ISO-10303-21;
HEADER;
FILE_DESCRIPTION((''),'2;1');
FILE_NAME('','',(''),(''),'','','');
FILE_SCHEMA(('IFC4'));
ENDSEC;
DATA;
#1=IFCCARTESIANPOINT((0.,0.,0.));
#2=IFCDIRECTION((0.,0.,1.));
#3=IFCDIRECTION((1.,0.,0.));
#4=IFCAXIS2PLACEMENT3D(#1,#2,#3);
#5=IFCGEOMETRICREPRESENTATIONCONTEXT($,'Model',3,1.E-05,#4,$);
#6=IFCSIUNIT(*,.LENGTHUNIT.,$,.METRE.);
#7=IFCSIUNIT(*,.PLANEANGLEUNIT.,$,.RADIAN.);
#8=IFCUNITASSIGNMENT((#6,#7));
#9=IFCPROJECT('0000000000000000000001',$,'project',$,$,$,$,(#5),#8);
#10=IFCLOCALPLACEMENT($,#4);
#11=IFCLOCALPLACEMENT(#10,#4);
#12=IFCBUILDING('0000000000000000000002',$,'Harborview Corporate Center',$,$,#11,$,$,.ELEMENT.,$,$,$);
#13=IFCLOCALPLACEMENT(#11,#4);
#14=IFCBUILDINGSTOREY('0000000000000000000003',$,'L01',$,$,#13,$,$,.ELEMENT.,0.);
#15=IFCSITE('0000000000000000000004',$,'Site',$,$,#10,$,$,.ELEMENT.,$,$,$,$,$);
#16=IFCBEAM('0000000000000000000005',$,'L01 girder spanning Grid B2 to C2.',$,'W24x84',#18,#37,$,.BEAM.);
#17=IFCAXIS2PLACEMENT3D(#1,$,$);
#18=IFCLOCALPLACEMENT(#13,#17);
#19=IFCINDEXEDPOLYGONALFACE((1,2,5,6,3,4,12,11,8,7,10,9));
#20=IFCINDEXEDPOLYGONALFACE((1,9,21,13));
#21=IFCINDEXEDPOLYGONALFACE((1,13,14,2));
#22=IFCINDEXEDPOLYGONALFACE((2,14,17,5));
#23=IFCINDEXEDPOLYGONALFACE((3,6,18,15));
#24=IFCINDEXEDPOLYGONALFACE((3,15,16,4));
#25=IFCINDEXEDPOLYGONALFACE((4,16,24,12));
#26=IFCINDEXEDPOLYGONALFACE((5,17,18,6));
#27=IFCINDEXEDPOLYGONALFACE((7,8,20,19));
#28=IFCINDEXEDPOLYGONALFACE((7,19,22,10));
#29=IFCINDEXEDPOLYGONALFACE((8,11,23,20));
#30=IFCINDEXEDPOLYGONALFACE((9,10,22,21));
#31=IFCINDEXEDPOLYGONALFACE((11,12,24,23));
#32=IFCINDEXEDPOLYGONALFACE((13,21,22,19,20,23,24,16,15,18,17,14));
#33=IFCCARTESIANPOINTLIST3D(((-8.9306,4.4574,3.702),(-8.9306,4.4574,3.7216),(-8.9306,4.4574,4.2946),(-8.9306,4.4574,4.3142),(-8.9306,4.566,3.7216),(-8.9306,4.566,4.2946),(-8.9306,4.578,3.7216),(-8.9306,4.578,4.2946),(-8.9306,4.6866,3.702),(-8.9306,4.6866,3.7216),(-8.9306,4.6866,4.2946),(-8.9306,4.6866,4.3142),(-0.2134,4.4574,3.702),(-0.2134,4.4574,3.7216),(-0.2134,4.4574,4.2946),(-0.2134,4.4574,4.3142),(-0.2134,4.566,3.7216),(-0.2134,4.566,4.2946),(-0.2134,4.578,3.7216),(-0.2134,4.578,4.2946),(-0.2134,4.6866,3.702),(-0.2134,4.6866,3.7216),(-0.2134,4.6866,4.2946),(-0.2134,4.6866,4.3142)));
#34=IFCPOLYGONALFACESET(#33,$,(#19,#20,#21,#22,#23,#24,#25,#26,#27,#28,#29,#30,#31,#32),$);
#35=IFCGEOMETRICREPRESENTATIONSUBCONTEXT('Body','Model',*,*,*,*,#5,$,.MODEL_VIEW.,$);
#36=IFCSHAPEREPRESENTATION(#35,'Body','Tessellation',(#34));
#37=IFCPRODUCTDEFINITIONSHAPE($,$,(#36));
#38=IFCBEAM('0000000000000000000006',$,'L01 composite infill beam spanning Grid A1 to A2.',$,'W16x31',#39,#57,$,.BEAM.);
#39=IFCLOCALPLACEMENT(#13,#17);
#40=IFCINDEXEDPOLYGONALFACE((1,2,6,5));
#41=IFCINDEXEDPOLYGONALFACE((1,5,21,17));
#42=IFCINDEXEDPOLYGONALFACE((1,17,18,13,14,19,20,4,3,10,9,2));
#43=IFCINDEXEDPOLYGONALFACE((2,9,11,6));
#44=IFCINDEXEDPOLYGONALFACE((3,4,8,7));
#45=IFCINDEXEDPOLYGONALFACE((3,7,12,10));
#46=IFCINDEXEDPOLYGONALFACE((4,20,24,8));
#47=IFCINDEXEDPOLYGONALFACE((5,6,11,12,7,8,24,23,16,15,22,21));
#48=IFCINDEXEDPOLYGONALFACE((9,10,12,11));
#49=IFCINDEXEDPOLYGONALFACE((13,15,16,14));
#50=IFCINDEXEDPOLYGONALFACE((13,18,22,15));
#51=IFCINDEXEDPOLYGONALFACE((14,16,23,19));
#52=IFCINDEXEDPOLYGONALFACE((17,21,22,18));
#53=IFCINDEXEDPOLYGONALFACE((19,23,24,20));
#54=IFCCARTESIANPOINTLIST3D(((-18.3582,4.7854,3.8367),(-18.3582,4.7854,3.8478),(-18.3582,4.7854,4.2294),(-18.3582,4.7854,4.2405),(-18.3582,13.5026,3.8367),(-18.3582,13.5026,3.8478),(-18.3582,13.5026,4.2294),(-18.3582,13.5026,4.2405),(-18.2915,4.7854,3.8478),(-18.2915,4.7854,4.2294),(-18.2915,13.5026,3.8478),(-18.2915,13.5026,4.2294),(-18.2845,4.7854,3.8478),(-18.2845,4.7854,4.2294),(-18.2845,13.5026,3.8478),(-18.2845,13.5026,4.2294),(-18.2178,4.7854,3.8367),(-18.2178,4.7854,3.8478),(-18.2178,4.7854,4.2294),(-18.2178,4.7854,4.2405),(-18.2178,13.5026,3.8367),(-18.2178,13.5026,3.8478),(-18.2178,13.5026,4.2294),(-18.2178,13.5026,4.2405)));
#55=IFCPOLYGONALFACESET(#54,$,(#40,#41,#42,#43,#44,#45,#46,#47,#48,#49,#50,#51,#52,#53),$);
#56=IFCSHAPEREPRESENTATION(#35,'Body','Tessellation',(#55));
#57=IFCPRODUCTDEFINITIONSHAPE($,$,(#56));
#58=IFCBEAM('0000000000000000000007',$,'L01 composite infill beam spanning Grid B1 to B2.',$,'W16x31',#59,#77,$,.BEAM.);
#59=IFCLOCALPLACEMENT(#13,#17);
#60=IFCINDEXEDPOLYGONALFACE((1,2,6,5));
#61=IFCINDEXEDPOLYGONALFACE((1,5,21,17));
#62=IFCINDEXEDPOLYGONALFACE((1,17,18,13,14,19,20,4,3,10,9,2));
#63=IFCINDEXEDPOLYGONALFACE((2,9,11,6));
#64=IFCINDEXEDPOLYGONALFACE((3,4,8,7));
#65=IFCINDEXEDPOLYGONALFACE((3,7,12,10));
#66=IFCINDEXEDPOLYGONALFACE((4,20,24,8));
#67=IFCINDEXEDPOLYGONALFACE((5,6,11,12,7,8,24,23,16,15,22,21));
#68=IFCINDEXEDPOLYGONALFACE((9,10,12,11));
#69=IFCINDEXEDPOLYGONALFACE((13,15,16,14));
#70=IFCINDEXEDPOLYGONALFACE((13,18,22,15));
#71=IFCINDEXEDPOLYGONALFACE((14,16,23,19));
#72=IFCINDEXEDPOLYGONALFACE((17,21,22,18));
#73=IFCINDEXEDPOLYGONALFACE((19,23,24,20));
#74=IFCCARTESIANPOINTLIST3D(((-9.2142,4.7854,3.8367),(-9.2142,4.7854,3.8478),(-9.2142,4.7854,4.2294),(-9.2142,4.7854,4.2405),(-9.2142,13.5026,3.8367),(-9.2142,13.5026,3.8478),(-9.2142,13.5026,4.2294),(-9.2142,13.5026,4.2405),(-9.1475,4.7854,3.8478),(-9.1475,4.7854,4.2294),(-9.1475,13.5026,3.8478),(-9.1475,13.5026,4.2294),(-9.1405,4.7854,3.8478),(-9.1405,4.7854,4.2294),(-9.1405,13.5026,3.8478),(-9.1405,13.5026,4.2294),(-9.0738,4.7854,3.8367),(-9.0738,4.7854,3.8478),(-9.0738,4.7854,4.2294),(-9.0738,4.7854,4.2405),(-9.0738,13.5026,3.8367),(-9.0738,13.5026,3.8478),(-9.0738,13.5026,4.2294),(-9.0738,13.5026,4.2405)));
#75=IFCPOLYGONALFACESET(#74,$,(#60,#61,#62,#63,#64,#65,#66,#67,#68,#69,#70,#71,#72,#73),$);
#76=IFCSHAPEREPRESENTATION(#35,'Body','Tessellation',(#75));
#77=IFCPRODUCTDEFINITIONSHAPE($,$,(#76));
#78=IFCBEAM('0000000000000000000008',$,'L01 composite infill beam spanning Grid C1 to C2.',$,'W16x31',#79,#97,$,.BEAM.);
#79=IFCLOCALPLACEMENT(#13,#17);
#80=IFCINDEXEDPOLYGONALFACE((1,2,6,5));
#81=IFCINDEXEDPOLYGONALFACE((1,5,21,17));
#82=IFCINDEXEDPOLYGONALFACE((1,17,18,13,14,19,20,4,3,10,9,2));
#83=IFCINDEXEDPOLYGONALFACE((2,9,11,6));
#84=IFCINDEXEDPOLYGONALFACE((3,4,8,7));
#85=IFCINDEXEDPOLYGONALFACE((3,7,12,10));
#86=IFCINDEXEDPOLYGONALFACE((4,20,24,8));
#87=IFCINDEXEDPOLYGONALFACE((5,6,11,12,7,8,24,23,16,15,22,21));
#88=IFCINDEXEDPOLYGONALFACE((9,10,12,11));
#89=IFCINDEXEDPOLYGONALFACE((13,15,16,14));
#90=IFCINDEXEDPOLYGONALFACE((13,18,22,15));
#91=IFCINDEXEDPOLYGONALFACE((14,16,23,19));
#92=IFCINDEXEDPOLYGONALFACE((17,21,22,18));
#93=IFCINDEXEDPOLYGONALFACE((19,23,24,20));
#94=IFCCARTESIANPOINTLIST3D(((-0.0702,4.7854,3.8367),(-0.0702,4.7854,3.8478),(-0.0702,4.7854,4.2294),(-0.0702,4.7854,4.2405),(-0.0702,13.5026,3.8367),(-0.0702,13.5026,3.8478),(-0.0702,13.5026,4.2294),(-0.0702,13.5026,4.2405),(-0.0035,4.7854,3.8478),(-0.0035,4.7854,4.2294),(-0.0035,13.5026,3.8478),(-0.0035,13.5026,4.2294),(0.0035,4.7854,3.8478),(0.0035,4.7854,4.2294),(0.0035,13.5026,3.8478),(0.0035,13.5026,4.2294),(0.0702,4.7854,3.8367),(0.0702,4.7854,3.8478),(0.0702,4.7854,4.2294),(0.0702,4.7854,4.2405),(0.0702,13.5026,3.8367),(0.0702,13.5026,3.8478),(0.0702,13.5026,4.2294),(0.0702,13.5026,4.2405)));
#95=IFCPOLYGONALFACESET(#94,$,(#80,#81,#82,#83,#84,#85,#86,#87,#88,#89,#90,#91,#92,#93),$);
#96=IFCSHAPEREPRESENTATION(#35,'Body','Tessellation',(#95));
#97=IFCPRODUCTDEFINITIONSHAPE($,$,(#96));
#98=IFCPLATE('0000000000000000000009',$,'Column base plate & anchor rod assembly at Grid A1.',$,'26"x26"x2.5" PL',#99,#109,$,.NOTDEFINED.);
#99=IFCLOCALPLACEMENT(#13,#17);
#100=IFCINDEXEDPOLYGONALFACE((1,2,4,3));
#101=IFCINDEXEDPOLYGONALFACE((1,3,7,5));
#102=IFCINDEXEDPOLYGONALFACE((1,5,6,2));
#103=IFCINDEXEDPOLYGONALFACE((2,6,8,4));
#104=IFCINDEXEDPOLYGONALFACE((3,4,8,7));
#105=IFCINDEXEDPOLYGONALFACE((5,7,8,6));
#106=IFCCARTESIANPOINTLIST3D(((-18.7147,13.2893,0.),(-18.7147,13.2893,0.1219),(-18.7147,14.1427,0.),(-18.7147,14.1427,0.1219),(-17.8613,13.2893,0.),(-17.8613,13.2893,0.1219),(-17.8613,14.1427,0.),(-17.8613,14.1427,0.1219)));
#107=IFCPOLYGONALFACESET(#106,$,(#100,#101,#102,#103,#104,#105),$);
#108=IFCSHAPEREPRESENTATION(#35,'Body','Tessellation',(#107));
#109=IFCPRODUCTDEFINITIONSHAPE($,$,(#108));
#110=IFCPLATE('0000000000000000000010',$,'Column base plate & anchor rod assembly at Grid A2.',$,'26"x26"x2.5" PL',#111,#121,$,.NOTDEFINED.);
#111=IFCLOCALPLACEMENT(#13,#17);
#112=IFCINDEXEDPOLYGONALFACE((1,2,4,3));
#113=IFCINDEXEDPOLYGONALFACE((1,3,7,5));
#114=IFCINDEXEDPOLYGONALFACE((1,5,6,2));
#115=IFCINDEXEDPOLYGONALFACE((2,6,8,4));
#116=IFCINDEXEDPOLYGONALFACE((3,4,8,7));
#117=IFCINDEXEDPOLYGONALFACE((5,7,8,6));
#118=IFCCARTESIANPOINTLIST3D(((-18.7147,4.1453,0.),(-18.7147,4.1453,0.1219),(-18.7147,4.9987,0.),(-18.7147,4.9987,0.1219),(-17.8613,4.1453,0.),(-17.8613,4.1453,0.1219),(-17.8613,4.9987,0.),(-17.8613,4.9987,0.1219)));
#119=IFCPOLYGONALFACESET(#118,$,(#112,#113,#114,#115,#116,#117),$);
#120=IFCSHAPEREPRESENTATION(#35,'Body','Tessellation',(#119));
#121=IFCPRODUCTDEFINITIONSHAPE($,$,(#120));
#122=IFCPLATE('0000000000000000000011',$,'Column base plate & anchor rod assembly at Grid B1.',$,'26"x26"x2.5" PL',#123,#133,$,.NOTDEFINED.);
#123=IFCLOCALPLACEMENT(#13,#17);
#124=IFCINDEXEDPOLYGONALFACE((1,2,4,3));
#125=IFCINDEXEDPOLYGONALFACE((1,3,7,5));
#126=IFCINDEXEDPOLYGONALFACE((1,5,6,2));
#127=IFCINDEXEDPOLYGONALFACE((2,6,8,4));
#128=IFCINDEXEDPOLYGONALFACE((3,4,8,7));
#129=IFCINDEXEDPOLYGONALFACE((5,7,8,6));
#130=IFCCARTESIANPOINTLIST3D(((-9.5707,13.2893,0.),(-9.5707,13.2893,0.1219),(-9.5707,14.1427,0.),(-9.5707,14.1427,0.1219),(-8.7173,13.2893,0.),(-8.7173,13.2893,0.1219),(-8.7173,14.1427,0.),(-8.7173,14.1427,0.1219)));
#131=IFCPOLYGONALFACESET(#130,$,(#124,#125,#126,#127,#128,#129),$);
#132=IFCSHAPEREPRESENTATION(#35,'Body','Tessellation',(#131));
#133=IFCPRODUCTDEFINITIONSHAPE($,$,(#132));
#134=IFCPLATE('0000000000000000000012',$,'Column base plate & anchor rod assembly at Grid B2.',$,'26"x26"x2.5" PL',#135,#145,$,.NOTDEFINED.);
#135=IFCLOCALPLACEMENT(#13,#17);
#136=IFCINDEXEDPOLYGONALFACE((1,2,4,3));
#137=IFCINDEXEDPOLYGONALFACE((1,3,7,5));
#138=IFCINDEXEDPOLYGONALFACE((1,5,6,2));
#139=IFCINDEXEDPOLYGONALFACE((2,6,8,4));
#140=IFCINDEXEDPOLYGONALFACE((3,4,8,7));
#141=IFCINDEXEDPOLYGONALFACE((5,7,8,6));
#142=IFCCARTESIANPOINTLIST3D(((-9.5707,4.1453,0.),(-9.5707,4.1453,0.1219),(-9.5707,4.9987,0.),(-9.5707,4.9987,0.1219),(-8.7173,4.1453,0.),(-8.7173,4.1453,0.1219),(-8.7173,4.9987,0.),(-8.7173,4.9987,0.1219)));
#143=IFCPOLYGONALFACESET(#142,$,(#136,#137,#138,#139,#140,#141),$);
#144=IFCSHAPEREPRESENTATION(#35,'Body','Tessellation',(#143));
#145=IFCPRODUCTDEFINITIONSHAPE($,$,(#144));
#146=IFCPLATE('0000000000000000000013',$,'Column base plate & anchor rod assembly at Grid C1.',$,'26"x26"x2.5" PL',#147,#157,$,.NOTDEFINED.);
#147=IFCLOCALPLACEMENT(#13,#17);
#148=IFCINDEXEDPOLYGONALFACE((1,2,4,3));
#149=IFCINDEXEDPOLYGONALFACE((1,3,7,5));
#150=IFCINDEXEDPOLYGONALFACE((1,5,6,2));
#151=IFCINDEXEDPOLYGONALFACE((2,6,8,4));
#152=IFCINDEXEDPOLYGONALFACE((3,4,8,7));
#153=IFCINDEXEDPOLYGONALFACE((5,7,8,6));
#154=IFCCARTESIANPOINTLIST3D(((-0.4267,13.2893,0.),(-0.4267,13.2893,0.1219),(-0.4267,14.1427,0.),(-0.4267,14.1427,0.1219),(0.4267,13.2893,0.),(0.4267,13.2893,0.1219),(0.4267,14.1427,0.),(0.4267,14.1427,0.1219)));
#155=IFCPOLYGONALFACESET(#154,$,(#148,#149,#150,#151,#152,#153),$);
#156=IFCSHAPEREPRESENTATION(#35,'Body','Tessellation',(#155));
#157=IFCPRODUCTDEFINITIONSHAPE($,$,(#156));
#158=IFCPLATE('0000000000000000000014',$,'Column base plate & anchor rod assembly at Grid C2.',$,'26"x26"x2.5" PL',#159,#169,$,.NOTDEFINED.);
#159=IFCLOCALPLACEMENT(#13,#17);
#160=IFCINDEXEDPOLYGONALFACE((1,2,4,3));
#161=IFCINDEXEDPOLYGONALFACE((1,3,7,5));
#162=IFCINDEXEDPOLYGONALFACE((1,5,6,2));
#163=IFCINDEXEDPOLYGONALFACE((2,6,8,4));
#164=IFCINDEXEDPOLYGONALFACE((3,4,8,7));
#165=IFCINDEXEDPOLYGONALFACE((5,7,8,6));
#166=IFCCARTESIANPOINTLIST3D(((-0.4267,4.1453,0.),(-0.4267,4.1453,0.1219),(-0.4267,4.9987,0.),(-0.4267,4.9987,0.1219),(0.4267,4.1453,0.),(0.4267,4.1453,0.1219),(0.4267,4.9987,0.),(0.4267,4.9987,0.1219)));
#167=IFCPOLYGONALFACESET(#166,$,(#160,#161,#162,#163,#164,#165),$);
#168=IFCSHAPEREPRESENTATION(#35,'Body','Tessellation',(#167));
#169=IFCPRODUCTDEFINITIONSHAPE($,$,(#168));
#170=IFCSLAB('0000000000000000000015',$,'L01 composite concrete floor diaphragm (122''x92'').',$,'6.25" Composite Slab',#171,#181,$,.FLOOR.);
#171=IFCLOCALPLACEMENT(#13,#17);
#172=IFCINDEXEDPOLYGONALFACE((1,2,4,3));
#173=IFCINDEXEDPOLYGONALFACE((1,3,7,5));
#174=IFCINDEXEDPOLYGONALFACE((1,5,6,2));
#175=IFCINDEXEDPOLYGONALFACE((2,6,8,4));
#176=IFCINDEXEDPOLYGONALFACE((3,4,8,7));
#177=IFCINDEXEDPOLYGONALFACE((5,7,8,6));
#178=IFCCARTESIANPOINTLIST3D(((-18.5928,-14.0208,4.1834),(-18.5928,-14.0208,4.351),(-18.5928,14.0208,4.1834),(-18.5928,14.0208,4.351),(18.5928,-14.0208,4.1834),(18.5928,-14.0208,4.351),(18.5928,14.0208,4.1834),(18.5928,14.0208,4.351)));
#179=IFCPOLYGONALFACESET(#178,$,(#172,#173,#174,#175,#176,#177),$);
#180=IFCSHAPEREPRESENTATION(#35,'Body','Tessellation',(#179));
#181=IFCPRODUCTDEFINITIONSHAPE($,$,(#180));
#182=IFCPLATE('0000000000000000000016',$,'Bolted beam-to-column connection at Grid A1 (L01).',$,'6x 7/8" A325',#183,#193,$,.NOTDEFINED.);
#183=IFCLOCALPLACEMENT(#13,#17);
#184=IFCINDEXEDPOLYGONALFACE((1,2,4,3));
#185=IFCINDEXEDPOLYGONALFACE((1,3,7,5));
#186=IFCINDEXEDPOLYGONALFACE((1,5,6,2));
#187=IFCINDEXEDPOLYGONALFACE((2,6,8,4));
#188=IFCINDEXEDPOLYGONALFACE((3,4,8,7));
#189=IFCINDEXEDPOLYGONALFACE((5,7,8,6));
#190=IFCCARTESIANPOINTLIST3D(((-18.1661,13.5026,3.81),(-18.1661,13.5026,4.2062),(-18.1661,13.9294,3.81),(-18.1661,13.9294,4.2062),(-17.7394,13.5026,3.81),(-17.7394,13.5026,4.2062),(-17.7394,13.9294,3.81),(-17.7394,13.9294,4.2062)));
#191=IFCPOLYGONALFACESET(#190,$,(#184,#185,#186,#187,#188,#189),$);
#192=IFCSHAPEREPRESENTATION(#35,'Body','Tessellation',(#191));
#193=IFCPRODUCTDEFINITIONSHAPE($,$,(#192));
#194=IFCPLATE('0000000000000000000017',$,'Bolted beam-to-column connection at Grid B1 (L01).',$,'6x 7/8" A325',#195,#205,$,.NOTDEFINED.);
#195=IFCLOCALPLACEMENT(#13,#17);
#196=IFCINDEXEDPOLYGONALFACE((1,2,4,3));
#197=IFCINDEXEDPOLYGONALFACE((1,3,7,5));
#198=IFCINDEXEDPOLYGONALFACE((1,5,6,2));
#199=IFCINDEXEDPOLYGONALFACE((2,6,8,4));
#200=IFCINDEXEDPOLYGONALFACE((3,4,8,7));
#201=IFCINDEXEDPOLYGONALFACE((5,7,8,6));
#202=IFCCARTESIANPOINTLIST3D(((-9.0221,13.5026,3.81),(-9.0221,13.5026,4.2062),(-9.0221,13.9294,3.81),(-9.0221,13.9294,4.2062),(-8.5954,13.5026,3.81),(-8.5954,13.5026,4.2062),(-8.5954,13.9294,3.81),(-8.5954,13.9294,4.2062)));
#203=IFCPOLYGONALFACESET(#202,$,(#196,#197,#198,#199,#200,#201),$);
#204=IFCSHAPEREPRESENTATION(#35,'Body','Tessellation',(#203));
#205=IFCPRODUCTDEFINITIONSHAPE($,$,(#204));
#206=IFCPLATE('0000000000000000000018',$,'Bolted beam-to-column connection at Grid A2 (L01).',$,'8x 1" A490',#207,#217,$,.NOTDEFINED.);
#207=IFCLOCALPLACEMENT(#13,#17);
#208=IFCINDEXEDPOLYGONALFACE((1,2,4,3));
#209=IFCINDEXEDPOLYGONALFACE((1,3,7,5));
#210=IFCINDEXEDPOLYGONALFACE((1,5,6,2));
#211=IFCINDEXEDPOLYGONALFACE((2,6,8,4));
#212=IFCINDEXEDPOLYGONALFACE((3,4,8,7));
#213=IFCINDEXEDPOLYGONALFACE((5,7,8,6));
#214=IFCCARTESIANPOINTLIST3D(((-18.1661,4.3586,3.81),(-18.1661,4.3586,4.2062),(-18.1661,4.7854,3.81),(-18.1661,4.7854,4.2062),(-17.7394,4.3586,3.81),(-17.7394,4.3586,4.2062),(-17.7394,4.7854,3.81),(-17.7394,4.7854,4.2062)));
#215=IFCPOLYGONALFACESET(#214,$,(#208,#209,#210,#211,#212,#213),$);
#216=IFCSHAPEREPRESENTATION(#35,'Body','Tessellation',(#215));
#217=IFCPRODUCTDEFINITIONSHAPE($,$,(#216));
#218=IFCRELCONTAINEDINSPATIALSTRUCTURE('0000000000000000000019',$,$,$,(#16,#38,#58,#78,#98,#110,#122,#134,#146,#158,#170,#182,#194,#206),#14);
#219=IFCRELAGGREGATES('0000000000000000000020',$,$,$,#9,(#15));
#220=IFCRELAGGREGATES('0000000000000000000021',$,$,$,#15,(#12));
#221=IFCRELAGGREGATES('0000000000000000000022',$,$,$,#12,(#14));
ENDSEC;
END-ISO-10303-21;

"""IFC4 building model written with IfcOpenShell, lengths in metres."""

from ifc_helpers import new_model, si_unit, frame, origin_with_axes, place, context, subcontext, project, spatial, rectangle, i_section, extrude, element, save


model = new_model("IFC4")

# Units and contexts
model_context = context("Model", 3, precision=1e-05, world=origin_with_axes())
body_context = subcontext(model_context, "Body", "Model", "MODEL_VIEW")
ifc_project = project(units=[si_unit("LENGTHUNIT", "METRE"), si_unit("PLANEANGLEUNIT", "RADIAN")], contexts=[model_context])

# Site, building, storey
site_placement = place(None, origin_with_axes())
site = spatial("IfcSite", under=ifc_project, at=site_placement, Name="Site", CompositionType="ELEMENT")
building_placement = place(site_placement, origin_with_axes())
building = spatial("IfcBuilding", under=site, at=building_placement, Name="Harborview Corporate Center", CompositionType="ELEMENT")
storey_placement = place(building_placement, origin_with_axes())
storey = spatial("IfcBuildingStorey", under=building, at=storey_placement, Name="L01", CompositionType="ELEMENT", Elevation=0.0)

# Beams
beam_1_placement = place(storey_placement, frame((-8.9306, 4.572, 4.0081), z_axis=(1.0, 0.0, 0.0), x_axis=(0.0, 1.0, 0.0)))
element("IfcBeam", 1, at=beam_1_placement, inside=storey, Name="L01 girder spanning Grid B2 to C2.", ObjectType="W24x84", PredefinedType="BEAM", context=body_context, shape_type="SweptSolid", body=[
    extrude(i_section(OverallWidth=0.2291, OverallDepth=0.6121, WebThickness=0.0119, FlangeThickness=0.0196), origin_with_axes(), (0.0, 0.0, 1.0), 8.7173),
])
for number, where, z_axis, x_axis, name in (
    (2, (-18.288, 4.7854, 4.0386), (0.0, 1.0, 0.0), (-1.0, 0.0, 0.0), "L01 composite infill beam spanning Grid A1 to A2."),
    (3, (-9.144, 4.7854, 4.0386), (0.0, 1.0, 0.0), (-1.0, 0.0, 0.0), "L01 composite infill beam spanning Grid B1 to B2."),
    (4, (0.0, 4.7854, 4.0386), (0.0, 1.0, 0.0), (-1.0, 0.0, 0.0), "L01 composite infill beam spanning Grid C1 to C2."),
):
    element("IfcBeam", number, at=place(storey_placement, frame(where, z_axis=z_axis, x_axis=x_axis)), inside=storey, Name=name, ObjectType="W16x31", PredefinedType="BEAM", context=body_context, shape_type="SweptSolid", body=[
        extrude(i_section(OverallWidth=0.1405, OverallDepth=0.4039, WebThickness=0.007, FlangeThickness=0.0112), origin_with_axes(), (0.0, 0.0, 1.0), 8.7173),
    ])

# Plates
plate_1_placement = place(storey_placement, frame((-18.288, 13.716, 0.0), z_axis=(0.0, 0.0, 1.0), x_axis=(1.0, 0.0, 0.0)))
element("IfcPlate", 5, at=plate_1_placement, inside=storey, Name="Column base plate & anchor rod assembly at Grid A1.", ObjectType="26\"x26\"x2.5\" PL", PredefinedType="NOTDEFINED", context=body_context, shape_type="SweptSolid", body=[
    extrude(rectangle(XDim=0.8534, YDim=0.8534), origin_with_axes(), (0.0, 0.0, 1.0), 0.1219),
])
plate_2_placement = place(storey_placement, frame((-18.288, 4.572, 0.0), z_axis=(0.0, 0.0, 1.0), x_axis=(1.0, 0.0, 0.0)))
element("IfcPlate", 6, at=plate_2_placement, inside=storey, Name="Column base plate & anchor rod assembly at Grid A2.", ObjectType="26\"x26\"x2.5\" PL", PredefinedType="NOTDEFINED", context=body_context, shape_type="SweptSolid", body=[
    extrude(rectangle(XDim=0.8534, YDim=0.8534), origin_with_axes(), (0.0, 0.0, 1.0), 0.1219),
])
plate_3_placement = place(storey_placement, frame((-9.144, 13.716, 0.0), z_axis=(0.0, 0.0, 1.0), x_axis=(1.0, 0.0, 0.0)))
element("IfcPlate", 7, at=plate_3_placement, inside=storey, Name="Column base plate & anchor rod assembly at Grid B1.", ObjectType="26\"x26\"x2.5\" PL", PredefinedType="NOTDEFINED", context=body_context, shape_type="SweptSolid", body=[
    extrude(rectangle(XDim=0.8534, YDim=0.8534), origin_with_axes(), (0.0, 0.0, 1.0), 0.1219),
])
plate_4_placement = place(storey_placement, frame((-9.144, 4.572, 0.0), z_axis=(0.0, 0.0, 1.0), x_axis=(1.0, 0.0, 0.0)))
element("IfcPlate", 8, at=plate_4_placement, inside=storey, Name="Column base plate & anchor rod assembly at Grid B2.", ObjectType="26\"x26\"x2.5\" PL", PredefinedType="NOTDEFINED", context=body_context, shape_type="SweptSolid", body=[
    extrude(rectangle(XDim=0.8534, YDim=0.8534), origin_with_axes(), (0.0, 0.0, 1.0), 0.1219),
])
plate_5_placement = place(storey_placement, frame((0.0, 13.716, 0.0), z_axis=(0.0, 0.0, 1.0), x_axis=(1.0, 0.0, 0.0)))
element("IfcPlate", 9, at=plate_5_placement, inside=storey, Name="Column base plate & anchor rod assembly at Grid C1.", ObjectType="26\"x26\"x2.5\" PL", PredefinedType="NOTDEFINED", context=body_context, shape_type="SweptSolid", body=[
    extrude(rectangle(XDim=0.8534, YDim=0.8534), origin_with_axes(), (0.0, 0.0, 1.0), 0.1219),
])
plate_6_placement = place(storey_placement, frame((0.0, 4.572, 0.0), z_axis=(0.0, 0.0, 1.0), x_axis=(1.0, 0.0, 0.0)))
element("IfcPlate", 10, at=plate_6_placement, inside=storey, Name="Column base plate & anchor rod assembly at Grid C2.", ObjectType="26\"x26\"x2.5\" PL", PredefinedType="NOTDEFINED", context=body_context, shape_type="SweptSolid", body=[
    extrude(rectangle(XDim=0.8534, YDim=0.8534), origin_with_axes(), (0.0, 0.0, 1.0), 0.1219),
])

# Slab
slab_placement = place(storey_placement, frame((0.0, 0.0, 4.1834), z_axis=(0.0, 0.0, 1.0), x_axis=(1.0, 0.0, 0.0)))
element("IfcSlab", 11, at=slab_placement, inside=storey, Name="L01 composite concrete floor diaphragm (122'x92').", ObjectType="6.25\" Composite Slab", PredefinedType="FLOOR", context=body_context, shape_type="SweptSolid", body=[
    extrude(rectangle(XDim=37.1856, YDim=28.0416), origin_with_axes(), (0.0, 0.0, 1.0), 0.1676),
])

# Plates
plate_7_placement = place(storey_placement, frame((-17.9527, 13.716, 3.81), z_axis=(0.0, 0.0, 1.0), x_axis=(1.0, 0.0, 0.0)))
element("IfcPlate", 12, at=plate_7_placement, inside=storey, Name="Bolted beam-to-column connection at Grid A1 (L01).", ObjectType="6x 7/8\" A325", PredefinedType="NOTDEFINED", context=body_context, shape_type="SweptSolid", body=[
    extrude(rectangle(XDim=0.4267, YDim=0.4267), origin_with_axes(), (0.0, 0.0, 1.0), 0.3962),
])
plate_8_placement = place(storey_placement, frame((-8.8087, 13.716, 3.81), z_axis=(0.0, 0.0, 1.0), x_axis=(1.0, 0.0, 0.0)))
element("IfcPlate", 13, at=plate_8_placement, inside=storey, Name="Bolted beam-to-column connection at Grid B1 (L01).", ObjectType="6x 7/8\" A325", PredefinedType="NOTDEFINED", context=body_context, shape_type="SweptSolid", body=[
    extrude(rectangle(XDim=0.4267, YDim=0.4267), origin_with_axes(), (0.0, 0.0, 1.0), 0.3962),
])
plate_9_placement = place(storey_placement, frame((-17.9527, 4.572, 3.81), z_axis=(0.0, 0.0, 1.0), x_axis=(1.0, 0.0, 0.0)))
element("IfcPlate", 14, at=plate_9_placement, inside=storey, Name="Bolted beam-to-column connection at Grid A2 (L01).", ObjectType="8x 1\" A490", PredefinedType="NOTDEFINED", context=body_context, shape_type="SweptSolid", body=[
    extrude(rectangle(XDim=0.4267, YDim=0.4267), origin_with_axes(), (0.0, 0.0, 1.0), 0.3962),
])

save(model, "model.ifc")
